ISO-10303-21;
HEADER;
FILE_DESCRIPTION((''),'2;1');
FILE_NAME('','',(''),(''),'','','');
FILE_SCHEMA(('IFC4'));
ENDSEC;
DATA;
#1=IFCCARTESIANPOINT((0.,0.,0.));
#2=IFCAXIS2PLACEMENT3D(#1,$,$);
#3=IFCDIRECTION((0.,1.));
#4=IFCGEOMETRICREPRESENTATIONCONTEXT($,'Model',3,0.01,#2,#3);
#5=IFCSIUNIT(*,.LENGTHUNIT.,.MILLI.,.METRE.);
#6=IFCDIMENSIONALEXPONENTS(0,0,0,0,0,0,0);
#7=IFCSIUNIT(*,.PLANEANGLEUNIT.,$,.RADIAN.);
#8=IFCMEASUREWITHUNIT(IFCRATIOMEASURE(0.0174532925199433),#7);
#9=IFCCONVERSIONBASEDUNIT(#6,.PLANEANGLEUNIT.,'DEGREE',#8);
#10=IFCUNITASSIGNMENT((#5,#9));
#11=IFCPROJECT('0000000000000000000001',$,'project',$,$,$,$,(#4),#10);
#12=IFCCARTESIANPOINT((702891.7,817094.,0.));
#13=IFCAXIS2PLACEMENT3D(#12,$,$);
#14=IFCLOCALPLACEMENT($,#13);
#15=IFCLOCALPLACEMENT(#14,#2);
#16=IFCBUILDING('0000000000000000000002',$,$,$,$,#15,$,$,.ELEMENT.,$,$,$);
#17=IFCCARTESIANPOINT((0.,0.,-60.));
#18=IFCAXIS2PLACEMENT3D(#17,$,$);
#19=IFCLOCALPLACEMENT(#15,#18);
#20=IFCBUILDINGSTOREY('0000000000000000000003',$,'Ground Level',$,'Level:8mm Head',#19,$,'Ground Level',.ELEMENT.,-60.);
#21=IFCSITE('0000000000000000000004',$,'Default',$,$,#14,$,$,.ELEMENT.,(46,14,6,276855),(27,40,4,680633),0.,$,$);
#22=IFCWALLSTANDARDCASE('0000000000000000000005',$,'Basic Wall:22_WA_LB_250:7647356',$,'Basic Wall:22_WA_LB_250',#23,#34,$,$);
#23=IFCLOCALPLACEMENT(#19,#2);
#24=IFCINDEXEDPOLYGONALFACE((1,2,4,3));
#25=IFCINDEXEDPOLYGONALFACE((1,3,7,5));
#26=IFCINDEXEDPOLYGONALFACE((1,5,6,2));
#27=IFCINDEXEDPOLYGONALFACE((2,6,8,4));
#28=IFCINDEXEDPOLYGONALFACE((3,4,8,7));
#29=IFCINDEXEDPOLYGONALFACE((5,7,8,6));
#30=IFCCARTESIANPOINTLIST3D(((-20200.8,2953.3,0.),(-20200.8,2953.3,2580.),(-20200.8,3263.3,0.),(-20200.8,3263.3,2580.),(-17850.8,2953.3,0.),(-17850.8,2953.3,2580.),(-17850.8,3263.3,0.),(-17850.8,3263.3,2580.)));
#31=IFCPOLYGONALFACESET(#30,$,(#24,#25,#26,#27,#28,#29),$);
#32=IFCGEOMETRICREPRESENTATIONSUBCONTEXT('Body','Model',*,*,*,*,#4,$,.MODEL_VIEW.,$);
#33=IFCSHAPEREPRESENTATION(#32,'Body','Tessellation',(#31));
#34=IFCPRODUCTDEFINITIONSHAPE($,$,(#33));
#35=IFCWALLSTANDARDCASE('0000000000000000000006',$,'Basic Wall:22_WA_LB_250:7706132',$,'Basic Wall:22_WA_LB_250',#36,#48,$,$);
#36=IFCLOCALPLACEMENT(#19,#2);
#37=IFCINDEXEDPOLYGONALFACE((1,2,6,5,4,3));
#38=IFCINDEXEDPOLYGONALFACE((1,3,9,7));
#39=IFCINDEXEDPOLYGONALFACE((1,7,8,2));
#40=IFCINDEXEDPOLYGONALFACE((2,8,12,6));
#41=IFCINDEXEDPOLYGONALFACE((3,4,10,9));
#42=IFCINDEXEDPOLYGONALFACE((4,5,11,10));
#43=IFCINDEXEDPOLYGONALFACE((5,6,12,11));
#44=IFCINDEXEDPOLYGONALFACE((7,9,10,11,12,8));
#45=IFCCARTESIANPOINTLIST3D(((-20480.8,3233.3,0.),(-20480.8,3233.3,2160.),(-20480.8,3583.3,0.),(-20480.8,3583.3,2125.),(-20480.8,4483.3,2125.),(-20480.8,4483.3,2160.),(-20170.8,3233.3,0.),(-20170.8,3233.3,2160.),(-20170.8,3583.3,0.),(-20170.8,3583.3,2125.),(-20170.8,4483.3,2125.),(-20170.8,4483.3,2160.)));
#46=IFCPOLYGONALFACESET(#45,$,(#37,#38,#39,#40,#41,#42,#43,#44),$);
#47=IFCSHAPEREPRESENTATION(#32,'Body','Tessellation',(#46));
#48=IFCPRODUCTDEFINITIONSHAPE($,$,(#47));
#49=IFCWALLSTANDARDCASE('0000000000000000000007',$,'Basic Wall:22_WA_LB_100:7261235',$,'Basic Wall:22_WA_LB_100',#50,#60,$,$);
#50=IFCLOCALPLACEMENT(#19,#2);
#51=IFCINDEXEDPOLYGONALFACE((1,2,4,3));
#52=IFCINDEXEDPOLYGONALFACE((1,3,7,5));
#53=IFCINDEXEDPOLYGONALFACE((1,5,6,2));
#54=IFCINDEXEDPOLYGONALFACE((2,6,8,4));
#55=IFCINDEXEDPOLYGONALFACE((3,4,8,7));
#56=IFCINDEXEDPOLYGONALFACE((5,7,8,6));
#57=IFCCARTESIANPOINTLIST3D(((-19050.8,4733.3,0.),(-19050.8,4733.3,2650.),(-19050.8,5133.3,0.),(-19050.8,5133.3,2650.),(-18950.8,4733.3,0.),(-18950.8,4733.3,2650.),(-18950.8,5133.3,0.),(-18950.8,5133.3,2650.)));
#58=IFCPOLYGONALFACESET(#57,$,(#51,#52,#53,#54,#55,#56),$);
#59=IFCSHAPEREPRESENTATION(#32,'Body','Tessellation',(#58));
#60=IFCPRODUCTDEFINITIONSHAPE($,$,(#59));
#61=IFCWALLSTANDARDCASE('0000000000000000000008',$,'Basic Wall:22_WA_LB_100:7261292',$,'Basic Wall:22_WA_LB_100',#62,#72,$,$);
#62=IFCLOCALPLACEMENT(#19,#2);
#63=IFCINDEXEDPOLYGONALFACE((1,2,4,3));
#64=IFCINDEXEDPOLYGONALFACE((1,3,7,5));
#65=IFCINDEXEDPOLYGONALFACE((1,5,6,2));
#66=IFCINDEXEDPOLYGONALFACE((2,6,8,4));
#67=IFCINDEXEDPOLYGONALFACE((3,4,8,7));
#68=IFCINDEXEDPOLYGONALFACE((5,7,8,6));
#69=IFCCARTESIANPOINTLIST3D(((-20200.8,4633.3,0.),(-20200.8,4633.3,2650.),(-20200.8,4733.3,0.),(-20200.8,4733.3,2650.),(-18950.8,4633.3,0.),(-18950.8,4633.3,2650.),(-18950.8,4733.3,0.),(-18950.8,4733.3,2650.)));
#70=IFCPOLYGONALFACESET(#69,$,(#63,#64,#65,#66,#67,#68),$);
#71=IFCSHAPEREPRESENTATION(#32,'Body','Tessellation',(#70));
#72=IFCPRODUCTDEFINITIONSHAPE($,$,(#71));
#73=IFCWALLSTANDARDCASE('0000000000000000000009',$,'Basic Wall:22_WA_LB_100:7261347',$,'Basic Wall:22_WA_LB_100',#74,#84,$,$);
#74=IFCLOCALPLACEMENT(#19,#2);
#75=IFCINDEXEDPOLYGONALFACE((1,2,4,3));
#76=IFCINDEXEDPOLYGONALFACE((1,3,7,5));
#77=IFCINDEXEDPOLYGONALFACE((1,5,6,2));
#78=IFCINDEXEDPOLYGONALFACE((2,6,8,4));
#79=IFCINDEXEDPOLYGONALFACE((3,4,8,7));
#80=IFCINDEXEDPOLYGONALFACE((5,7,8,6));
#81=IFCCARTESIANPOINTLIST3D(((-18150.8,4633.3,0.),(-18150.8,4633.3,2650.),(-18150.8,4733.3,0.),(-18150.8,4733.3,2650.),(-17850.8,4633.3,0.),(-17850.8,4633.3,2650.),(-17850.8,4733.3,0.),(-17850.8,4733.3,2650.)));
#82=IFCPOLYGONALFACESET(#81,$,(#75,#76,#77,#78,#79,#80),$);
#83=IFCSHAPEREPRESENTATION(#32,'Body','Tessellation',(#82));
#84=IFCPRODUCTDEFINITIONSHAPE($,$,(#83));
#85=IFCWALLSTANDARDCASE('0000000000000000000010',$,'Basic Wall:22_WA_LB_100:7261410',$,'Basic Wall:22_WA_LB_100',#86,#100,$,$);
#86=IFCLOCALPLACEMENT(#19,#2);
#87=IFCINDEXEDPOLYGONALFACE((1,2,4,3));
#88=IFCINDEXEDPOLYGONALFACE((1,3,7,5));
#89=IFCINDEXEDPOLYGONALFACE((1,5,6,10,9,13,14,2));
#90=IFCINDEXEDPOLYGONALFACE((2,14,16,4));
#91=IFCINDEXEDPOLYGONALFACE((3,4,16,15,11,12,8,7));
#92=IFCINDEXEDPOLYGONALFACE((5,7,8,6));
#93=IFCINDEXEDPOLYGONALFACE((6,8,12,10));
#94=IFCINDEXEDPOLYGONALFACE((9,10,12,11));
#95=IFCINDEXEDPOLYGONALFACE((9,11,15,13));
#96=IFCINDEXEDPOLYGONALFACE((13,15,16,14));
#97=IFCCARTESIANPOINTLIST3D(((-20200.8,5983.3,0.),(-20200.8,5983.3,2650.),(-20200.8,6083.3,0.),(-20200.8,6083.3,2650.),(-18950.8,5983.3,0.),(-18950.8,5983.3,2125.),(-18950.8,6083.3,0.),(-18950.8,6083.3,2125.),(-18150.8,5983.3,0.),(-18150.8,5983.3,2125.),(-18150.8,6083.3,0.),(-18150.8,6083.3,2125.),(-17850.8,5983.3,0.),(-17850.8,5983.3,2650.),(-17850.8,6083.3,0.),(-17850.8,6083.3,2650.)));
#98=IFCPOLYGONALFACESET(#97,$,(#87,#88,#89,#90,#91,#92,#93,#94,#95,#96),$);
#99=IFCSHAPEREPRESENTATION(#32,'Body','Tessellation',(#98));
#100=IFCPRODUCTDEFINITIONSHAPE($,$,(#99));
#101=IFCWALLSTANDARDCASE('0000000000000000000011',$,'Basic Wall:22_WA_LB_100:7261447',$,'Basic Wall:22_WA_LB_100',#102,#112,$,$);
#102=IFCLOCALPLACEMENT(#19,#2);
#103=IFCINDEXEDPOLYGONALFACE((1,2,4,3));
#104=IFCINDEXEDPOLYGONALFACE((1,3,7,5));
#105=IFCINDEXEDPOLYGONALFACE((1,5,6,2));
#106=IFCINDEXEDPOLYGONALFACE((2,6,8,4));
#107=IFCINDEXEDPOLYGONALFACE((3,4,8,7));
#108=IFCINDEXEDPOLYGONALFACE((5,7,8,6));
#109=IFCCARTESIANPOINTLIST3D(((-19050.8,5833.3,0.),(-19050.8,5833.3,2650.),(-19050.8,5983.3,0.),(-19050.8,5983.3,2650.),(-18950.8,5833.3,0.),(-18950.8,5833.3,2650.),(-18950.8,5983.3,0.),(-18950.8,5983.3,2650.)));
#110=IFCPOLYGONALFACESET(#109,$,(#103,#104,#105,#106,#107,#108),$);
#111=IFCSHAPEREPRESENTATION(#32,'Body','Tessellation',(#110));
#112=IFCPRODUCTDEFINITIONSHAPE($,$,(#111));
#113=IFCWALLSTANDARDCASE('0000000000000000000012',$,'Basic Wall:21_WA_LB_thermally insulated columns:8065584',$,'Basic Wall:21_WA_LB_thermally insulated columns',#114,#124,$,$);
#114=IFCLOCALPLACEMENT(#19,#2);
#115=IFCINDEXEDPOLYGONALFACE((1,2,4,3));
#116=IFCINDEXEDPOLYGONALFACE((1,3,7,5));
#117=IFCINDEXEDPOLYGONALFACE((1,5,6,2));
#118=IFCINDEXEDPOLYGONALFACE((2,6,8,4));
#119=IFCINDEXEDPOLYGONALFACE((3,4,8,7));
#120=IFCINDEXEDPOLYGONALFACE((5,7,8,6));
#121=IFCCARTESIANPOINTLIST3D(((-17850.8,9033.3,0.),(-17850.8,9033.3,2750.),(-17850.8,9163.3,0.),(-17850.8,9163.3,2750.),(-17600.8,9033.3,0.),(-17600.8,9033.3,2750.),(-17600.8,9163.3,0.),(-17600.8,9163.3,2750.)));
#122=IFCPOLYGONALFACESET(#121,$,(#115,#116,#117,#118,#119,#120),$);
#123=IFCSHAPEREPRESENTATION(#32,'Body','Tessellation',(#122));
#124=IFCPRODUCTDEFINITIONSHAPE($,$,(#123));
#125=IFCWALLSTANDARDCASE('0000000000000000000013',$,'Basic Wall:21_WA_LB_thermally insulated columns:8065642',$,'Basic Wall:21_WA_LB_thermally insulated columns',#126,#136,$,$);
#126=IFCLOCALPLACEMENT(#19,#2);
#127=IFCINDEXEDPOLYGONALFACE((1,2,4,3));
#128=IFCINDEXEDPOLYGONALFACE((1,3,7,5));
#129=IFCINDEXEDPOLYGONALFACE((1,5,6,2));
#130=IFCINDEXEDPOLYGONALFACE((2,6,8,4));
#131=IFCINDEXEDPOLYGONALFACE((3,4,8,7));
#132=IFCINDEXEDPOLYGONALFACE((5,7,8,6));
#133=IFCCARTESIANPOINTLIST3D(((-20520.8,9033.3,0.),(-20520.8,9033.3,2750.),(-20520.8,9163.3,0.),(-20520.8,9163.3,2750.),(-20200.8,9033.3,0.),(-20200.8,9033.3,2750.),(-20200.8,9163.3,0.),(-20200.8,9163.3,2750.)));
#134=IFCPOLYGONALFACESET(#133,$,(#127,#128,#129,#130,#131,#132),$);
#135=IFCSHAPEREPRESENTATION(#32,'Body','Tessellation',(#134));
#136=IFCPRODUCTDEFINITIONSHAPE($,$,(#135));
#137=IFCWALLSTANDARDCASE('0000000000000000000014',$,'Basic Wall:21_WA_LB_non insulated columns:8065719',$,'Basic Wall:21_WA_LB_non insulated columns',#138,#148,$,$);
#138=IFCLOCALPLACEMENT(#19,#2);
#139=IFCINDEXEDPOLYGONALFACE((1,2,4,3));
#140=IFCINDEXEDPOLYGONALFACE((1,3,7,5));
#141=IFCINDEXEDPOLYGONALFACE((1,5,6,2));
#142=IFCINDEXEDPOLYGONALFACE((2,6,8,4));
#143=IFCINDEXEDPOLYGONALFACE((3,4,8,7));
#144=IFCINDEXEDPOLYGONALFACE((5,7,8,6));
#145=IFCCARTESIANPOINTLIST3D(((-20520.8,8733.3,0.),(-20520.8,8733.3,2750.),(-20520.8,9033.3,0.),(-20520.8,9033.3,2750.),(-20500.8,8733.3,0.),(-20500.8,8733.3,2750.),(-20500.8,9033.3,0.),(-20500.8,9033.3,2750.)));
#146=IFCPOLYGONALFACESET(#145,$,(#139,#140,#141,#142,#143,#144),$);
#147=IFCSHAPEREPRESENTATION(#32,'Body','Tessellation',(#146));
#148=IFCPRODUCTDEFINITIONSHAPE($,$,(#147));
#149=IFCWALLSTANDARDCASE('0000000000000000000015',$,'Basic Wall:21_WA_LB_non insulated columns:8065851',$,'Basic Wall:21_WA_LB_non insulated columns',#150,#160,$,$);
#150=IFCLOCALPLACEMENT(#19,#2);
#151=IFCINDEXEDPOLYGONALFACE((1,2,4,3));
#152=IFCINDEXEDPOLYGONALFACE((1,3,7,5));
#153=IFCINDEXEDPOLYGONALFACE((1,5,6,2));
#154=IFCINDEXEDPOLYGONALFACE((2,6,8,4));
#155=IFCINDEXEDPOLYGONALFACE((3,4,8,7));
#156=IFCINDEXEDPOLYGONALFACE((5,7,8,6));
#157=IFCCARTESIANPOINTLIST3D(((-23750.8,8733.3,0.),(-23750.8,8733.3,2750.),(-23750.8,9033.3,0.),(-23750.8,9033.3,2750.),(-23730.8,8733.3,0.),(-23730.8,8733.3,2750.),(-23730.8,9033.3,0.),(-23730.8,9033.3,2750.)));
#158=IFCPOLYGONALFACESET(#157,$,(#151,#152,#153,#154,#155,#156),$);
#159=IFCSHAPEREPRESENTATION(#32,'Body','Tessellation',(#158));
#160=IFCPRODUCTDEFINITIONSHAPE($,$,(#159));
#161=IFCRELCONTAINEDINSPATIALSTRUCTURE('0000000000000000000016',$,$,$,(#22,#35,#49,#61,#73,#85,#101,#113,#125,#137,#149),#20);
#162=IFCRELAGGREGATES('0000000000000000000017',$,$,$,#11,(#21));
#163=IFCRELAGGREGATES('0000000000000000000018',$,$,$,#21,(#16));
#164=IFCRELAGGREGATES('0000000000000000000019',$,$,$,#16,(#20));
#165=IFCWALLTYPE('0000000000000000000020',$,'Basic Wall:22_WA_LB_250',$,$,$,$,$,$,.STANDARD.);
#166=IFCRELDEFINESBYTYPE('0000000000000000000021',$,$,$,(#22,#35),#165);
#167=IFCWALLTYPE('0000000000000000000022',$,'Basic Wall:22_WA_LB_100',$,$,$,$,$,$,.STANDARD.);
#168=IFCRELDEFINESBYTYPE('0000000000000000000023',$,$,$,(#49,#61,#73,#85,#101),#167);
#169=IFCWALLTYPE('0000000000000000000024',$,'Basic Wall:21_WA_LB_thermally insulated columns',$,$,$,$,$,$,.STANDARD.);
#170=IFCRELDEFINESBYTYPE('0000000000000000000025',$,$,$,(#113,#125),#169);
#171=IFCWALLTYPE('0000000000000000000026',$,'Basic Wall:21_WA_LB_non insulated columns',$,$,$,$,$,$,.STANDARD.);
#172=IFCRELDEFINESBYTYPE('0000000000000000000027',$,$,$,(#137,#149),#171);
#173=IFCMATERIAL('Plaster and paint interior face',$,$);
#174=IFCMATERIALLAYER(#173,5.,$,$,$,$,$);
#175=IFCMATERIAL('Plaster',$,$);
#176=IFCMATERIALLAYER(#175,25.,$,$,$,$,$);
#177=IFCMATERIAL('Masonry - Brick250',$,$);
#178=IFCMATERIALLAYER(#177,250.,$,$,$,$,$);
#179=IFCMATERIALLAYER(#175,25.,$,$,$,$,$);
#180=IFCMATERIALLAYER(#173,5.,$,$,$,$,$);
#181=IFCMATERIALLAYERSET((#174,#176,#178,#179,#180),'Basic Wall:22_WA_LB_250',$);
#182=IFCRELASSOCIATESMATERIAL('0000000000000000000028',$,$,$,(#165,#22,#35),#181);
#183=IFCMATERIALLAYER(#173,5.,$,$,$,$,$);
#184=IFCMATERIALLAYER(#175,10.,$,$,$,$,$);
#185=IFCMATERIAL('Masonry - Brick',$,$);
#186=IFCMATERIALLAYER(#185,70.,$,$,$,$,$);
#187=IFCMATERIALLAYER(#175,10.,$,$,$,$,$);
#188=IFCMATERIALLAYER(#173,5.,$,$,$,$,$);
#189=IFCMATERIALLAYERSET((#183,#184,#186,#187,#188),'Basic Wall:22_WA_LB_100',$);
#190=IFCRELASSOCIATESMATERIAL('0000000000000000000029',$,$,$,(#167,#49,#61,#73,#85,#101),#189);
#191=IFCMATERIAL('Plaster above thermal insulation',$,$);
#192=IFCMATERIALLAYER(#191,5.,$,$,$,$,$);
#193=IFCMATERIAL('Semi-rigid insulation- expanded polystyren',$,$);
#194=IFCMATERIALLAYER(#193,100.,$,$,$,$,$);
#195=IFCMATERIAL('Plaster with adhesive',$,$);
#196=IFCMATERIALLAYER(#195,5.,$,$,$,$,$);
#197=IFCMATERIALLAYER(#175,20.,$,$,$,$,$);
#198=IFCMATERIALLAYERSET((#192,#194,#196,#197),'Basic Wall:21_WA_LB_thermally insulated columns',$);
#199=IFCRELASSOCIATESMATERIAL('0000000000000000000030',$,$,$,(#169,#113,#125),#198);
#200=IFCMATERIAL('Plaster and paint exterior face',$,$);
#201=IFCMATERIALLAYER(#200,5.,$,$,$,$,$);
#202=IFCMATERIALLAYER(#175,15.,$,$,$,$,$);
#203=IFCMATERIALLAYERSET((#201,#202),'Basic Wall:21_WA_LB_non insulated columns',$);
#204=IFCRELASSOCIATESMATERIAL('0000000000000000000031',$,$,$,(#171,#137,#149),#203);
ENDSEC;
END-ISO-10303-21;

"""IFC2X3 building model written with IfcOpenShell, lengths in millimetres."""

from ifc_helpers import new_model, entity, si_unit, converted_unit, direction, frame, frame_2d, origin, place, context, subcontext, project, spatial, rectangle, extrude, clip, halfspace, material, layer, layer_set, layer_usage, type_object, element, save


model = new_model("IFC2X3")

# Units and contexts
model_context = context("Model", 3, precision=0.01, world=origin(), true_north=direction((0.0, 1.0)))
body_context = subcontext(model_context, "Body", "Model", "MODEL_VIEW")
ifc_project = project(units=[si_unit("LENGTHUNIT", "METRE", prefix="MILLI"), converted_unit("PLANEANGLEUNIT", "DEGREE", entity("IfcRatioMeasure", 0.0174532925199433), si_unit("PLANEANGLEUNIT", "RADIAN"), dimensions=[0, 0, 0, 0, 0, 0, 0])], contexts=[model_context])

# Site, building, storey
site_placement = place(None, frame((702891.7, 817094.0, 0.0)))
site = spatial("IfcSite", under=ifc_project, at=site_placement, Name="Default", CompositionType="ELEMENT", RefLatitude=(46, 14, 6, 276855), RefLongitude=(27, 40, 4, 680633), RefElevation=0.0)
building_placement = place(site_placement, origin())
building = spatial("IfcBuilding", under=site, at=building_placement, CompositionType="ELEMENT")
storey_placement = place(building_placement, frame((0.0, 0.0, -60.0)))
storey = spatial("IfcBuildingStorey", under=building, at=storey_placement, Name="Ground Level", ObjectType="Level:8mm Head", LongName="Ground Level", CompositionType="ELEMENT", Elevation=-60.0)

# Shared definitions
ifc_material_1 = material(Name="Plaster above thermal insulation")
ifc_material_2 = material(Name="Semi-rigid insulation- expanded polystyren")
ifc_material_3 = material(Name="Plaster with adhesive")
ifc_material_4 = material(Name="Plaster")
ifc_material_5 = material(Name="Masonry - Brick")
ifc_material_6 = material(Name="Plaster and paint interior face")

# Shared definitions
ifc_material_7 = material(Name="Plaster and paint exterior face")

# Wall
ifc_layer_1 = layer(ifc_material_6, 5.0)
ifc_layer_2 = layer(ifc_material_4, 25.0)
ifc_material_8 = material(Name="Masonry - Brick250")
ifc_layer_3 = layer(ifc_material_8, 250.0)
ifc_layer_4 = layer(ifc_material_4, 25.0)
ifc_layer_5 = layer(ifc_material_6, 5.0)
ifc_layer_set_1 = layer_set([ifc_layer_1, ifc_layer_2, ifc_layer_3, ifc_layer_4, ifc_layer_5], Name="Basic Wall:22_WA_LB_250")
wall_type_1 = type_object("IfcWallType", Name="Basic Wall:22_WA_LB_250", PredefinedType="STANDARD", material=ifc_layer_set_1)
ifc_layer_usage_1 = layer_usage(ifc_layer_set_1, "AXIS2", "NEGATIVE", 155.0)
wall_1_placement = place(storey_placement, frame((-20200.8, 3108.3, 0.0)))
element("IfcWallStandardCase", 1, at=wall_1_placement, inside=storey, type_object=wall_type_1, material=ifc_layer_usage_1, Name="Basic Wall:22_WA_LB_250:7647356", ObjectType="Basic Wall:22_WA_LB_250", context=body_context, shape_type="SweptSolid", body=[
    extrude(rectangle(XDim=2350.0, YDim=310.0, at=frame_2d((1175.0, 0.0), x_axis=(-1.0, 0.0))), origin(), (0.0, 0.0, 1.0), 2580.0),
])

# Wall, opening
ifc_layer_usage_2 = layer_usage(ifc_layer_set_1, "AXIS2", "NEGATIVE", 155.0)
wall_2_placement = place(storey_placement, frame((-20325.8, 4483.3, 0.0), z_axis=(0.0, 0.0, 1.0), x_axis=(0.0, -1.0, 0.0)))
wall_2 = element("IfcWallStandardCase", 2, at=wall_2_placement, inside=storey, type_object=wall_type_1, material=ifc_layer_usage_2, Name="Basic Wall:22_WA_LB_250:7706132", ObjectType="Basic Wall:22_WA_LB_250", context=body_context, shape_type="SweptSolid", body=[
    extrude(rectangle(XDim=1250.0, YDim=310.0, at=frame_2d((625.0, 0.0), x_axis=(-1.0, 0.0))), origin(), (0.0, 0.0, 1.0), 2160.0),
])
opening_1_placement = place(wall_2_placement, frame((4483.3, 20325.8, 0.0), z_axis=(0.0, 0.0, 1.0), x_axis=(0.0, 1.0, 0.0)))
element("IfcOpeningElement", 3, at=opening_1_placement, cuts=wall_2, ObjectType="Opening", context=body_context, shape_type="SweptSolid", body=[
    extrude(rectangle(XDim=2125.0, YDim=900.0, at=frame_2d((0.0, 0.0), x_axis=(1.0, 0.0))), frame((-22004.8, 4033.3, 1062.5), z_axis=(1.0, 0.0, 0.0), x_axis=(0.0, 0.0, 1.0)), (0.0, 0.0, 1.0), 3048.0),
])

# Walls
ifc_layer_6 = layer(ifc_material_6, 5.0)
ifc_layer_7 = layer(ifc_material_4, 10.0)
ifc_layer_8 = layer(ifc_material_5, 70.0)
ifc_layer_9 = layer(ifc_material_4, 10.0)
ifc_layer_10 = layer(ifc_material_6, 5.0)
ifc_layer_set_2 = layer_set([ifc_layer_6, ifc_layer_7, ifc_layer_8, ifc_layer_9, ifc_layer_10], Name="Basic Wall:22_WA_LB_100")
ifc_layer_usage_3 = layer_usage(ifc_layer_set_2, "AXIS2", "NEGATIVE", 50.0)
wall_type_2 = type_object("IfcWallType", Name="Basic Wall:22_WA_LB_100", PredefinedType="STANDARD", material=ifc_layer_set_2)
wall_3_placement = place(storey_placement, frame((-19000.8, 5133.3, 0.0), z_axis=(0.0, 0.0, 1.0), x_axis=(0.0, -1.0, 0.0)))
element("IfcWallStandardCase", 4, at=wall_3_placement, inside=storey, type_object=wall_type_2, material=ifc_layer_usage_3, Name="Basic Wall:22_WA_LB_100:7261235", ObjectType="Basic Wall:22_WA_LB_100", context=body_context, shape_type="SweptSolid", body=[
    extrude(rectangle(XDim=400.0, YDim=100.0, at=frame_2d((200.0, 0.0), x_axis=(-1.0, 0.0))), origin(), (0.0, 0.0, 1.0), 2650.0),
])
ifc_layer_usage_4 = layer_usage(ifc_layer_set_2, "AXIS2", "NEGATIVE", 50.0)
wall_4_placement = place(storey_placement, frame((-18950.8, 4683.3, 0.0), z_axis=(0.0, 0.0, 1.0), x_axis=(-1.0, 0.0, 0.0)))
element("IfcWallStandardCase", 5, at=wall_4_placement, inside=storey, type_object=wall_type_2, material=ifc_layer_usage_4, Name="Basic Wall:22_WA_LB_100:7261292", ObjectType="Basic Wall:22_WA_LB_100", context=body_context, shape_type="SweptSolid", body=[
    extrude(rectangle(XDim=1250.0, YDim=100.0, at=frame_2d((625.0, 0.0), x_axis=(-1.0, 0.0))), origin(), (0.0, 0.0, 1.0), 2650.0),
])
ifc_layer_usage_5 = layer_usage(ifc_layer_set_2, "AXIS2", "NEGATIVE", 50.0)
wall_5_placement = place(storey_placement, frame((-18150.8, 4683.3, 0.0)))
element("IfcWallStandardCase", 6, at=wall_5_placement, inside=storey, type_object=wall_type_2, material=ifc_layer_usage_5, Name="Basic Wall:22_WA_LB_100:7261347", ObjectType="Basic Wall:22_WA_LB_100", context=body_context, shape_type="SweptSolid", body=[
    extrude(rectangle(XDim=300.0, YDim=100.0, at=frame_2d((150.0, 0.0), x_axis=(-1.0, 0.0))), origin(), (0.0, 0.0, 1.0), 2650.0),
])

# Wall, opening
ifc_layer_usage_6 = layer_usage(ifc_layer_set_2, "AXIS2", "NEGATIVE", 50.0)
wall_6_placement = place(storey_placement, frame((-17850.8, 6033.3, 0.0), z_axis=(0.0, 0.0, 1.0), x_axis=(-1.0, 0.0, 0.0)))
wall_6 = element("IfcWallStandardCase", 7, at=wall_6_placement, inside=storey, type_object=wall_type_2, material=ifc_layer_usage_6, Name="Basic Wall:22_WA_LB_100:7261410", ObjectType="Basic Wall:22_WA_LB_100", context=body_context, shape_type="SweptSolid", body=[
    extrude(rectangle(XDim=2350.0, YDim=100.0, at=frame_2d((1175.0, 0.0), x_axis=(-1.0, 0.0))), origin(), (0.0, 0.0, 1.0), 2650.0),
])
opening_2_placement = place(wall_6_placement, frame((-17850.8, 6033.3, 0.0), z_axis=(0.0, 0.0, 1.0), x_axis=(-1.0, 0.0, 0.0)))
element("IfcOpeningElement", 8, at=opening_2_placement, cuts=wall_6, ObjectType="Opening", context=body_context, shape_type="SweptSolid", body=[
    extrude(rectangle(XDim=2125.0, YDim=800.0, at=frame_2d((0.0, 0.0), x_axis=(0.0, 1.0))), frame((-18550.8, 7507.3, 1062.5), z_axis=(0.0, -1.0, 0.0), x_axis=(1.0, 0.0, 0.0)), (0.0, 0.0, 1.0), 3048.0),
])

# Walls
ifc_layer_usage_7 = layer_usage(ifc_layer_set_2, "AXIS2", "NEGATIVE", 50.0)
wall_7_placement = place(storey_placement, frame((-19000.8, 5983.3, 0.0), z_axis=(0.0, 0.0, 1.0), x_axis=(0.0, -1.0, 0.0)))
element("IfcWallStandardCase", 9, at=wall_7_placement, inside=storey, type_object=wall_type_2, material=ifc_layer_usage_7, Name="Basic Wall:22_WA_LB_100:7261447", ObjectType="Basic Wall:22_WA_LB_100", context=body_context, shape_type="SweptSolid", body=[
    extrude(rectangle(XDim=150.0, YDim=100.0, at=frame_2d((75.0, 0.0), x_axis=(-1.0, 0.0))), origin(), (0.0, 0.0, 1.0), 2650.0),
])
ifc_layer_11 = layer(ifc_material_1, 5.0)
ifc_layer_12 = layer(ifc_material_2, 100.0)
ifc_layer_13 = layer(ifc_material_3, 5.0)
ifc_layer_14 = layer(ifc_material_4, 20.0)
ifc_layer_set_3 = layer_set([ifc_layer_11, ifc_layer_12, ifc_layer_13, ifc_layer_14], Name="Basic Wall:21_WA_LB_thermally insulated columns")
ifc_layer_usage_8 = layer_usage(ifc_layer_set_3, "AXIS2", "NEGATIVE", 65.0)
wall_type_3 = type_object("IfcWallType", Name="Basic Wall:21_WA_LB_thermally insulated columns", PredefinedType="STANDARD", material=ifc_layer_set_3)
wall_8_placement = place(storey_placement, frame((-17850.8, 9098.3, 0.0)))
element("IfcWallStandardCase", 10, at=wall_8_placement, inside=storey, type_object=wall_type_3, material=ifc_layer_usage_8, Name="Basic Wall:21_WA_LB_thermally insulated columns:8065584", ObjectType="Basic Wall:21_WA_LB_thermally insulated columns", context=body_context, shape_type="Clipping", body=[
    clip(extrude(rectangle(XDim=250.0, YDim=130.0, at=frame_2d((125.0, 0.0), x_axis=(-1.0, 0.0))), origin(), (0.0, 0.0, 1.0), 2750.0), halfspace(origin(), True)),
])
ifc_layer_usage_9 = layer_usage(ifc_layer_set_3, "AXIS2", "NEGATIVE", 65.0)
wall_9_placement = place(storey_placement, frame((-20520.8, 9098.3, 0.0)))
element("IfcWallStandardCase", 11, at=wall_9_placement, inside=storey, type_object=wall_type_3, material=ifc_layer_usage_9, Name="Basic Wall:21_WA_LB_thermally insulated columns:8065642", ObjectType="Basic Wall:21_WA_LB_thermally insulated columns", context=body_context, shape_type="Clipping", body=[
    clip(extrude(rectangle(XDim=320.0, YDim=130.0, at=frame_2d((160.0, 0.0), x_axis=(-1.0, 0.0))), origin(), (0.0, 0.0, 1.0), 2750.0), halfspace(origin(), True)),
])
ifc_layer_15 = layer(ifc_material_7, 5.0)
ifc_layer_16 = layer(ifc_material_4, 15.0)
ifc_layer_set_4 = layer_set([ifc_layer_15, ifc_layer_16], Name="Basic Wall:21_WA_LB_non insulated columns")
ifc_layer_usage_10 = layer_usage(ifc_layer_set_4, "AXIS2", "NEGATIVE", 10.0)
wall_type_4 = type_object("IfcWallType", Name="Basic Wall:21_WA_LB_non insulated columns", PredefinedType="STANDARD", material=ifc_layer_set_4)
wall_10_placement = place(storey_placement, frame((-20510.8, 8733.3, 0.0), z_axis=(0.0, 0.0, 1.0), x_axis=(0.0, 1.0, 0.0)))
element("IfcWallStandardCase", 12, at=wall_10_placement, inside=storey, type_object=wall_type_4, material=ifc_layer_usage_10, Name="Basic Wall:21_WA_LB_non insulated columns:8065719", ObjectType="Basic Wall:21_WA_LB_non insulated columns", context=body_context, shape_type="Clipping", body=[
    clip(extrude(rectangle(XDim=300.0, YDim=20.0, at=frame_2d((150.0, 0.0), x_axis=(-1.0, 0.0))), origin(), (0.0, 0.0, 1.0), 2750.0), halfspace(origin(), True)),
])
ifc_layer_usage_11 = layer_usage(ifc_layer_set_4, "AXIS2", "POSITIVE", -10.0)
wall_11_placement = place(storey_placement, frame((-23740.8, 8733.3, 0.0), z_axis=(0.0, 0.0, 1.0), x_axis=(0.0, 1.0, 0.0)))
element("IfcWallStandardCase", 13, at=wall_11_placement, inside=storey, type_object=wall_type_4, material=ifc_layer_usage_11, Name="Basic Wall:21_WA_LB_non insulated columns:8065851", ObjectType="Basic Wall:21_WA_LB_non insulated columns", context=body_context, shape_type="Clipping", body=[
    clip(extrude(rectangle(XDim=300.0, YDim=20.0, at=frame_2d((150.0, 0.0), x_axis=(-1.0, 0.0))), origin(), (0.0, 0.0, 1.0), 2750.0), halfspace(origin(), True)),
])

save(model, "model.ifc")
